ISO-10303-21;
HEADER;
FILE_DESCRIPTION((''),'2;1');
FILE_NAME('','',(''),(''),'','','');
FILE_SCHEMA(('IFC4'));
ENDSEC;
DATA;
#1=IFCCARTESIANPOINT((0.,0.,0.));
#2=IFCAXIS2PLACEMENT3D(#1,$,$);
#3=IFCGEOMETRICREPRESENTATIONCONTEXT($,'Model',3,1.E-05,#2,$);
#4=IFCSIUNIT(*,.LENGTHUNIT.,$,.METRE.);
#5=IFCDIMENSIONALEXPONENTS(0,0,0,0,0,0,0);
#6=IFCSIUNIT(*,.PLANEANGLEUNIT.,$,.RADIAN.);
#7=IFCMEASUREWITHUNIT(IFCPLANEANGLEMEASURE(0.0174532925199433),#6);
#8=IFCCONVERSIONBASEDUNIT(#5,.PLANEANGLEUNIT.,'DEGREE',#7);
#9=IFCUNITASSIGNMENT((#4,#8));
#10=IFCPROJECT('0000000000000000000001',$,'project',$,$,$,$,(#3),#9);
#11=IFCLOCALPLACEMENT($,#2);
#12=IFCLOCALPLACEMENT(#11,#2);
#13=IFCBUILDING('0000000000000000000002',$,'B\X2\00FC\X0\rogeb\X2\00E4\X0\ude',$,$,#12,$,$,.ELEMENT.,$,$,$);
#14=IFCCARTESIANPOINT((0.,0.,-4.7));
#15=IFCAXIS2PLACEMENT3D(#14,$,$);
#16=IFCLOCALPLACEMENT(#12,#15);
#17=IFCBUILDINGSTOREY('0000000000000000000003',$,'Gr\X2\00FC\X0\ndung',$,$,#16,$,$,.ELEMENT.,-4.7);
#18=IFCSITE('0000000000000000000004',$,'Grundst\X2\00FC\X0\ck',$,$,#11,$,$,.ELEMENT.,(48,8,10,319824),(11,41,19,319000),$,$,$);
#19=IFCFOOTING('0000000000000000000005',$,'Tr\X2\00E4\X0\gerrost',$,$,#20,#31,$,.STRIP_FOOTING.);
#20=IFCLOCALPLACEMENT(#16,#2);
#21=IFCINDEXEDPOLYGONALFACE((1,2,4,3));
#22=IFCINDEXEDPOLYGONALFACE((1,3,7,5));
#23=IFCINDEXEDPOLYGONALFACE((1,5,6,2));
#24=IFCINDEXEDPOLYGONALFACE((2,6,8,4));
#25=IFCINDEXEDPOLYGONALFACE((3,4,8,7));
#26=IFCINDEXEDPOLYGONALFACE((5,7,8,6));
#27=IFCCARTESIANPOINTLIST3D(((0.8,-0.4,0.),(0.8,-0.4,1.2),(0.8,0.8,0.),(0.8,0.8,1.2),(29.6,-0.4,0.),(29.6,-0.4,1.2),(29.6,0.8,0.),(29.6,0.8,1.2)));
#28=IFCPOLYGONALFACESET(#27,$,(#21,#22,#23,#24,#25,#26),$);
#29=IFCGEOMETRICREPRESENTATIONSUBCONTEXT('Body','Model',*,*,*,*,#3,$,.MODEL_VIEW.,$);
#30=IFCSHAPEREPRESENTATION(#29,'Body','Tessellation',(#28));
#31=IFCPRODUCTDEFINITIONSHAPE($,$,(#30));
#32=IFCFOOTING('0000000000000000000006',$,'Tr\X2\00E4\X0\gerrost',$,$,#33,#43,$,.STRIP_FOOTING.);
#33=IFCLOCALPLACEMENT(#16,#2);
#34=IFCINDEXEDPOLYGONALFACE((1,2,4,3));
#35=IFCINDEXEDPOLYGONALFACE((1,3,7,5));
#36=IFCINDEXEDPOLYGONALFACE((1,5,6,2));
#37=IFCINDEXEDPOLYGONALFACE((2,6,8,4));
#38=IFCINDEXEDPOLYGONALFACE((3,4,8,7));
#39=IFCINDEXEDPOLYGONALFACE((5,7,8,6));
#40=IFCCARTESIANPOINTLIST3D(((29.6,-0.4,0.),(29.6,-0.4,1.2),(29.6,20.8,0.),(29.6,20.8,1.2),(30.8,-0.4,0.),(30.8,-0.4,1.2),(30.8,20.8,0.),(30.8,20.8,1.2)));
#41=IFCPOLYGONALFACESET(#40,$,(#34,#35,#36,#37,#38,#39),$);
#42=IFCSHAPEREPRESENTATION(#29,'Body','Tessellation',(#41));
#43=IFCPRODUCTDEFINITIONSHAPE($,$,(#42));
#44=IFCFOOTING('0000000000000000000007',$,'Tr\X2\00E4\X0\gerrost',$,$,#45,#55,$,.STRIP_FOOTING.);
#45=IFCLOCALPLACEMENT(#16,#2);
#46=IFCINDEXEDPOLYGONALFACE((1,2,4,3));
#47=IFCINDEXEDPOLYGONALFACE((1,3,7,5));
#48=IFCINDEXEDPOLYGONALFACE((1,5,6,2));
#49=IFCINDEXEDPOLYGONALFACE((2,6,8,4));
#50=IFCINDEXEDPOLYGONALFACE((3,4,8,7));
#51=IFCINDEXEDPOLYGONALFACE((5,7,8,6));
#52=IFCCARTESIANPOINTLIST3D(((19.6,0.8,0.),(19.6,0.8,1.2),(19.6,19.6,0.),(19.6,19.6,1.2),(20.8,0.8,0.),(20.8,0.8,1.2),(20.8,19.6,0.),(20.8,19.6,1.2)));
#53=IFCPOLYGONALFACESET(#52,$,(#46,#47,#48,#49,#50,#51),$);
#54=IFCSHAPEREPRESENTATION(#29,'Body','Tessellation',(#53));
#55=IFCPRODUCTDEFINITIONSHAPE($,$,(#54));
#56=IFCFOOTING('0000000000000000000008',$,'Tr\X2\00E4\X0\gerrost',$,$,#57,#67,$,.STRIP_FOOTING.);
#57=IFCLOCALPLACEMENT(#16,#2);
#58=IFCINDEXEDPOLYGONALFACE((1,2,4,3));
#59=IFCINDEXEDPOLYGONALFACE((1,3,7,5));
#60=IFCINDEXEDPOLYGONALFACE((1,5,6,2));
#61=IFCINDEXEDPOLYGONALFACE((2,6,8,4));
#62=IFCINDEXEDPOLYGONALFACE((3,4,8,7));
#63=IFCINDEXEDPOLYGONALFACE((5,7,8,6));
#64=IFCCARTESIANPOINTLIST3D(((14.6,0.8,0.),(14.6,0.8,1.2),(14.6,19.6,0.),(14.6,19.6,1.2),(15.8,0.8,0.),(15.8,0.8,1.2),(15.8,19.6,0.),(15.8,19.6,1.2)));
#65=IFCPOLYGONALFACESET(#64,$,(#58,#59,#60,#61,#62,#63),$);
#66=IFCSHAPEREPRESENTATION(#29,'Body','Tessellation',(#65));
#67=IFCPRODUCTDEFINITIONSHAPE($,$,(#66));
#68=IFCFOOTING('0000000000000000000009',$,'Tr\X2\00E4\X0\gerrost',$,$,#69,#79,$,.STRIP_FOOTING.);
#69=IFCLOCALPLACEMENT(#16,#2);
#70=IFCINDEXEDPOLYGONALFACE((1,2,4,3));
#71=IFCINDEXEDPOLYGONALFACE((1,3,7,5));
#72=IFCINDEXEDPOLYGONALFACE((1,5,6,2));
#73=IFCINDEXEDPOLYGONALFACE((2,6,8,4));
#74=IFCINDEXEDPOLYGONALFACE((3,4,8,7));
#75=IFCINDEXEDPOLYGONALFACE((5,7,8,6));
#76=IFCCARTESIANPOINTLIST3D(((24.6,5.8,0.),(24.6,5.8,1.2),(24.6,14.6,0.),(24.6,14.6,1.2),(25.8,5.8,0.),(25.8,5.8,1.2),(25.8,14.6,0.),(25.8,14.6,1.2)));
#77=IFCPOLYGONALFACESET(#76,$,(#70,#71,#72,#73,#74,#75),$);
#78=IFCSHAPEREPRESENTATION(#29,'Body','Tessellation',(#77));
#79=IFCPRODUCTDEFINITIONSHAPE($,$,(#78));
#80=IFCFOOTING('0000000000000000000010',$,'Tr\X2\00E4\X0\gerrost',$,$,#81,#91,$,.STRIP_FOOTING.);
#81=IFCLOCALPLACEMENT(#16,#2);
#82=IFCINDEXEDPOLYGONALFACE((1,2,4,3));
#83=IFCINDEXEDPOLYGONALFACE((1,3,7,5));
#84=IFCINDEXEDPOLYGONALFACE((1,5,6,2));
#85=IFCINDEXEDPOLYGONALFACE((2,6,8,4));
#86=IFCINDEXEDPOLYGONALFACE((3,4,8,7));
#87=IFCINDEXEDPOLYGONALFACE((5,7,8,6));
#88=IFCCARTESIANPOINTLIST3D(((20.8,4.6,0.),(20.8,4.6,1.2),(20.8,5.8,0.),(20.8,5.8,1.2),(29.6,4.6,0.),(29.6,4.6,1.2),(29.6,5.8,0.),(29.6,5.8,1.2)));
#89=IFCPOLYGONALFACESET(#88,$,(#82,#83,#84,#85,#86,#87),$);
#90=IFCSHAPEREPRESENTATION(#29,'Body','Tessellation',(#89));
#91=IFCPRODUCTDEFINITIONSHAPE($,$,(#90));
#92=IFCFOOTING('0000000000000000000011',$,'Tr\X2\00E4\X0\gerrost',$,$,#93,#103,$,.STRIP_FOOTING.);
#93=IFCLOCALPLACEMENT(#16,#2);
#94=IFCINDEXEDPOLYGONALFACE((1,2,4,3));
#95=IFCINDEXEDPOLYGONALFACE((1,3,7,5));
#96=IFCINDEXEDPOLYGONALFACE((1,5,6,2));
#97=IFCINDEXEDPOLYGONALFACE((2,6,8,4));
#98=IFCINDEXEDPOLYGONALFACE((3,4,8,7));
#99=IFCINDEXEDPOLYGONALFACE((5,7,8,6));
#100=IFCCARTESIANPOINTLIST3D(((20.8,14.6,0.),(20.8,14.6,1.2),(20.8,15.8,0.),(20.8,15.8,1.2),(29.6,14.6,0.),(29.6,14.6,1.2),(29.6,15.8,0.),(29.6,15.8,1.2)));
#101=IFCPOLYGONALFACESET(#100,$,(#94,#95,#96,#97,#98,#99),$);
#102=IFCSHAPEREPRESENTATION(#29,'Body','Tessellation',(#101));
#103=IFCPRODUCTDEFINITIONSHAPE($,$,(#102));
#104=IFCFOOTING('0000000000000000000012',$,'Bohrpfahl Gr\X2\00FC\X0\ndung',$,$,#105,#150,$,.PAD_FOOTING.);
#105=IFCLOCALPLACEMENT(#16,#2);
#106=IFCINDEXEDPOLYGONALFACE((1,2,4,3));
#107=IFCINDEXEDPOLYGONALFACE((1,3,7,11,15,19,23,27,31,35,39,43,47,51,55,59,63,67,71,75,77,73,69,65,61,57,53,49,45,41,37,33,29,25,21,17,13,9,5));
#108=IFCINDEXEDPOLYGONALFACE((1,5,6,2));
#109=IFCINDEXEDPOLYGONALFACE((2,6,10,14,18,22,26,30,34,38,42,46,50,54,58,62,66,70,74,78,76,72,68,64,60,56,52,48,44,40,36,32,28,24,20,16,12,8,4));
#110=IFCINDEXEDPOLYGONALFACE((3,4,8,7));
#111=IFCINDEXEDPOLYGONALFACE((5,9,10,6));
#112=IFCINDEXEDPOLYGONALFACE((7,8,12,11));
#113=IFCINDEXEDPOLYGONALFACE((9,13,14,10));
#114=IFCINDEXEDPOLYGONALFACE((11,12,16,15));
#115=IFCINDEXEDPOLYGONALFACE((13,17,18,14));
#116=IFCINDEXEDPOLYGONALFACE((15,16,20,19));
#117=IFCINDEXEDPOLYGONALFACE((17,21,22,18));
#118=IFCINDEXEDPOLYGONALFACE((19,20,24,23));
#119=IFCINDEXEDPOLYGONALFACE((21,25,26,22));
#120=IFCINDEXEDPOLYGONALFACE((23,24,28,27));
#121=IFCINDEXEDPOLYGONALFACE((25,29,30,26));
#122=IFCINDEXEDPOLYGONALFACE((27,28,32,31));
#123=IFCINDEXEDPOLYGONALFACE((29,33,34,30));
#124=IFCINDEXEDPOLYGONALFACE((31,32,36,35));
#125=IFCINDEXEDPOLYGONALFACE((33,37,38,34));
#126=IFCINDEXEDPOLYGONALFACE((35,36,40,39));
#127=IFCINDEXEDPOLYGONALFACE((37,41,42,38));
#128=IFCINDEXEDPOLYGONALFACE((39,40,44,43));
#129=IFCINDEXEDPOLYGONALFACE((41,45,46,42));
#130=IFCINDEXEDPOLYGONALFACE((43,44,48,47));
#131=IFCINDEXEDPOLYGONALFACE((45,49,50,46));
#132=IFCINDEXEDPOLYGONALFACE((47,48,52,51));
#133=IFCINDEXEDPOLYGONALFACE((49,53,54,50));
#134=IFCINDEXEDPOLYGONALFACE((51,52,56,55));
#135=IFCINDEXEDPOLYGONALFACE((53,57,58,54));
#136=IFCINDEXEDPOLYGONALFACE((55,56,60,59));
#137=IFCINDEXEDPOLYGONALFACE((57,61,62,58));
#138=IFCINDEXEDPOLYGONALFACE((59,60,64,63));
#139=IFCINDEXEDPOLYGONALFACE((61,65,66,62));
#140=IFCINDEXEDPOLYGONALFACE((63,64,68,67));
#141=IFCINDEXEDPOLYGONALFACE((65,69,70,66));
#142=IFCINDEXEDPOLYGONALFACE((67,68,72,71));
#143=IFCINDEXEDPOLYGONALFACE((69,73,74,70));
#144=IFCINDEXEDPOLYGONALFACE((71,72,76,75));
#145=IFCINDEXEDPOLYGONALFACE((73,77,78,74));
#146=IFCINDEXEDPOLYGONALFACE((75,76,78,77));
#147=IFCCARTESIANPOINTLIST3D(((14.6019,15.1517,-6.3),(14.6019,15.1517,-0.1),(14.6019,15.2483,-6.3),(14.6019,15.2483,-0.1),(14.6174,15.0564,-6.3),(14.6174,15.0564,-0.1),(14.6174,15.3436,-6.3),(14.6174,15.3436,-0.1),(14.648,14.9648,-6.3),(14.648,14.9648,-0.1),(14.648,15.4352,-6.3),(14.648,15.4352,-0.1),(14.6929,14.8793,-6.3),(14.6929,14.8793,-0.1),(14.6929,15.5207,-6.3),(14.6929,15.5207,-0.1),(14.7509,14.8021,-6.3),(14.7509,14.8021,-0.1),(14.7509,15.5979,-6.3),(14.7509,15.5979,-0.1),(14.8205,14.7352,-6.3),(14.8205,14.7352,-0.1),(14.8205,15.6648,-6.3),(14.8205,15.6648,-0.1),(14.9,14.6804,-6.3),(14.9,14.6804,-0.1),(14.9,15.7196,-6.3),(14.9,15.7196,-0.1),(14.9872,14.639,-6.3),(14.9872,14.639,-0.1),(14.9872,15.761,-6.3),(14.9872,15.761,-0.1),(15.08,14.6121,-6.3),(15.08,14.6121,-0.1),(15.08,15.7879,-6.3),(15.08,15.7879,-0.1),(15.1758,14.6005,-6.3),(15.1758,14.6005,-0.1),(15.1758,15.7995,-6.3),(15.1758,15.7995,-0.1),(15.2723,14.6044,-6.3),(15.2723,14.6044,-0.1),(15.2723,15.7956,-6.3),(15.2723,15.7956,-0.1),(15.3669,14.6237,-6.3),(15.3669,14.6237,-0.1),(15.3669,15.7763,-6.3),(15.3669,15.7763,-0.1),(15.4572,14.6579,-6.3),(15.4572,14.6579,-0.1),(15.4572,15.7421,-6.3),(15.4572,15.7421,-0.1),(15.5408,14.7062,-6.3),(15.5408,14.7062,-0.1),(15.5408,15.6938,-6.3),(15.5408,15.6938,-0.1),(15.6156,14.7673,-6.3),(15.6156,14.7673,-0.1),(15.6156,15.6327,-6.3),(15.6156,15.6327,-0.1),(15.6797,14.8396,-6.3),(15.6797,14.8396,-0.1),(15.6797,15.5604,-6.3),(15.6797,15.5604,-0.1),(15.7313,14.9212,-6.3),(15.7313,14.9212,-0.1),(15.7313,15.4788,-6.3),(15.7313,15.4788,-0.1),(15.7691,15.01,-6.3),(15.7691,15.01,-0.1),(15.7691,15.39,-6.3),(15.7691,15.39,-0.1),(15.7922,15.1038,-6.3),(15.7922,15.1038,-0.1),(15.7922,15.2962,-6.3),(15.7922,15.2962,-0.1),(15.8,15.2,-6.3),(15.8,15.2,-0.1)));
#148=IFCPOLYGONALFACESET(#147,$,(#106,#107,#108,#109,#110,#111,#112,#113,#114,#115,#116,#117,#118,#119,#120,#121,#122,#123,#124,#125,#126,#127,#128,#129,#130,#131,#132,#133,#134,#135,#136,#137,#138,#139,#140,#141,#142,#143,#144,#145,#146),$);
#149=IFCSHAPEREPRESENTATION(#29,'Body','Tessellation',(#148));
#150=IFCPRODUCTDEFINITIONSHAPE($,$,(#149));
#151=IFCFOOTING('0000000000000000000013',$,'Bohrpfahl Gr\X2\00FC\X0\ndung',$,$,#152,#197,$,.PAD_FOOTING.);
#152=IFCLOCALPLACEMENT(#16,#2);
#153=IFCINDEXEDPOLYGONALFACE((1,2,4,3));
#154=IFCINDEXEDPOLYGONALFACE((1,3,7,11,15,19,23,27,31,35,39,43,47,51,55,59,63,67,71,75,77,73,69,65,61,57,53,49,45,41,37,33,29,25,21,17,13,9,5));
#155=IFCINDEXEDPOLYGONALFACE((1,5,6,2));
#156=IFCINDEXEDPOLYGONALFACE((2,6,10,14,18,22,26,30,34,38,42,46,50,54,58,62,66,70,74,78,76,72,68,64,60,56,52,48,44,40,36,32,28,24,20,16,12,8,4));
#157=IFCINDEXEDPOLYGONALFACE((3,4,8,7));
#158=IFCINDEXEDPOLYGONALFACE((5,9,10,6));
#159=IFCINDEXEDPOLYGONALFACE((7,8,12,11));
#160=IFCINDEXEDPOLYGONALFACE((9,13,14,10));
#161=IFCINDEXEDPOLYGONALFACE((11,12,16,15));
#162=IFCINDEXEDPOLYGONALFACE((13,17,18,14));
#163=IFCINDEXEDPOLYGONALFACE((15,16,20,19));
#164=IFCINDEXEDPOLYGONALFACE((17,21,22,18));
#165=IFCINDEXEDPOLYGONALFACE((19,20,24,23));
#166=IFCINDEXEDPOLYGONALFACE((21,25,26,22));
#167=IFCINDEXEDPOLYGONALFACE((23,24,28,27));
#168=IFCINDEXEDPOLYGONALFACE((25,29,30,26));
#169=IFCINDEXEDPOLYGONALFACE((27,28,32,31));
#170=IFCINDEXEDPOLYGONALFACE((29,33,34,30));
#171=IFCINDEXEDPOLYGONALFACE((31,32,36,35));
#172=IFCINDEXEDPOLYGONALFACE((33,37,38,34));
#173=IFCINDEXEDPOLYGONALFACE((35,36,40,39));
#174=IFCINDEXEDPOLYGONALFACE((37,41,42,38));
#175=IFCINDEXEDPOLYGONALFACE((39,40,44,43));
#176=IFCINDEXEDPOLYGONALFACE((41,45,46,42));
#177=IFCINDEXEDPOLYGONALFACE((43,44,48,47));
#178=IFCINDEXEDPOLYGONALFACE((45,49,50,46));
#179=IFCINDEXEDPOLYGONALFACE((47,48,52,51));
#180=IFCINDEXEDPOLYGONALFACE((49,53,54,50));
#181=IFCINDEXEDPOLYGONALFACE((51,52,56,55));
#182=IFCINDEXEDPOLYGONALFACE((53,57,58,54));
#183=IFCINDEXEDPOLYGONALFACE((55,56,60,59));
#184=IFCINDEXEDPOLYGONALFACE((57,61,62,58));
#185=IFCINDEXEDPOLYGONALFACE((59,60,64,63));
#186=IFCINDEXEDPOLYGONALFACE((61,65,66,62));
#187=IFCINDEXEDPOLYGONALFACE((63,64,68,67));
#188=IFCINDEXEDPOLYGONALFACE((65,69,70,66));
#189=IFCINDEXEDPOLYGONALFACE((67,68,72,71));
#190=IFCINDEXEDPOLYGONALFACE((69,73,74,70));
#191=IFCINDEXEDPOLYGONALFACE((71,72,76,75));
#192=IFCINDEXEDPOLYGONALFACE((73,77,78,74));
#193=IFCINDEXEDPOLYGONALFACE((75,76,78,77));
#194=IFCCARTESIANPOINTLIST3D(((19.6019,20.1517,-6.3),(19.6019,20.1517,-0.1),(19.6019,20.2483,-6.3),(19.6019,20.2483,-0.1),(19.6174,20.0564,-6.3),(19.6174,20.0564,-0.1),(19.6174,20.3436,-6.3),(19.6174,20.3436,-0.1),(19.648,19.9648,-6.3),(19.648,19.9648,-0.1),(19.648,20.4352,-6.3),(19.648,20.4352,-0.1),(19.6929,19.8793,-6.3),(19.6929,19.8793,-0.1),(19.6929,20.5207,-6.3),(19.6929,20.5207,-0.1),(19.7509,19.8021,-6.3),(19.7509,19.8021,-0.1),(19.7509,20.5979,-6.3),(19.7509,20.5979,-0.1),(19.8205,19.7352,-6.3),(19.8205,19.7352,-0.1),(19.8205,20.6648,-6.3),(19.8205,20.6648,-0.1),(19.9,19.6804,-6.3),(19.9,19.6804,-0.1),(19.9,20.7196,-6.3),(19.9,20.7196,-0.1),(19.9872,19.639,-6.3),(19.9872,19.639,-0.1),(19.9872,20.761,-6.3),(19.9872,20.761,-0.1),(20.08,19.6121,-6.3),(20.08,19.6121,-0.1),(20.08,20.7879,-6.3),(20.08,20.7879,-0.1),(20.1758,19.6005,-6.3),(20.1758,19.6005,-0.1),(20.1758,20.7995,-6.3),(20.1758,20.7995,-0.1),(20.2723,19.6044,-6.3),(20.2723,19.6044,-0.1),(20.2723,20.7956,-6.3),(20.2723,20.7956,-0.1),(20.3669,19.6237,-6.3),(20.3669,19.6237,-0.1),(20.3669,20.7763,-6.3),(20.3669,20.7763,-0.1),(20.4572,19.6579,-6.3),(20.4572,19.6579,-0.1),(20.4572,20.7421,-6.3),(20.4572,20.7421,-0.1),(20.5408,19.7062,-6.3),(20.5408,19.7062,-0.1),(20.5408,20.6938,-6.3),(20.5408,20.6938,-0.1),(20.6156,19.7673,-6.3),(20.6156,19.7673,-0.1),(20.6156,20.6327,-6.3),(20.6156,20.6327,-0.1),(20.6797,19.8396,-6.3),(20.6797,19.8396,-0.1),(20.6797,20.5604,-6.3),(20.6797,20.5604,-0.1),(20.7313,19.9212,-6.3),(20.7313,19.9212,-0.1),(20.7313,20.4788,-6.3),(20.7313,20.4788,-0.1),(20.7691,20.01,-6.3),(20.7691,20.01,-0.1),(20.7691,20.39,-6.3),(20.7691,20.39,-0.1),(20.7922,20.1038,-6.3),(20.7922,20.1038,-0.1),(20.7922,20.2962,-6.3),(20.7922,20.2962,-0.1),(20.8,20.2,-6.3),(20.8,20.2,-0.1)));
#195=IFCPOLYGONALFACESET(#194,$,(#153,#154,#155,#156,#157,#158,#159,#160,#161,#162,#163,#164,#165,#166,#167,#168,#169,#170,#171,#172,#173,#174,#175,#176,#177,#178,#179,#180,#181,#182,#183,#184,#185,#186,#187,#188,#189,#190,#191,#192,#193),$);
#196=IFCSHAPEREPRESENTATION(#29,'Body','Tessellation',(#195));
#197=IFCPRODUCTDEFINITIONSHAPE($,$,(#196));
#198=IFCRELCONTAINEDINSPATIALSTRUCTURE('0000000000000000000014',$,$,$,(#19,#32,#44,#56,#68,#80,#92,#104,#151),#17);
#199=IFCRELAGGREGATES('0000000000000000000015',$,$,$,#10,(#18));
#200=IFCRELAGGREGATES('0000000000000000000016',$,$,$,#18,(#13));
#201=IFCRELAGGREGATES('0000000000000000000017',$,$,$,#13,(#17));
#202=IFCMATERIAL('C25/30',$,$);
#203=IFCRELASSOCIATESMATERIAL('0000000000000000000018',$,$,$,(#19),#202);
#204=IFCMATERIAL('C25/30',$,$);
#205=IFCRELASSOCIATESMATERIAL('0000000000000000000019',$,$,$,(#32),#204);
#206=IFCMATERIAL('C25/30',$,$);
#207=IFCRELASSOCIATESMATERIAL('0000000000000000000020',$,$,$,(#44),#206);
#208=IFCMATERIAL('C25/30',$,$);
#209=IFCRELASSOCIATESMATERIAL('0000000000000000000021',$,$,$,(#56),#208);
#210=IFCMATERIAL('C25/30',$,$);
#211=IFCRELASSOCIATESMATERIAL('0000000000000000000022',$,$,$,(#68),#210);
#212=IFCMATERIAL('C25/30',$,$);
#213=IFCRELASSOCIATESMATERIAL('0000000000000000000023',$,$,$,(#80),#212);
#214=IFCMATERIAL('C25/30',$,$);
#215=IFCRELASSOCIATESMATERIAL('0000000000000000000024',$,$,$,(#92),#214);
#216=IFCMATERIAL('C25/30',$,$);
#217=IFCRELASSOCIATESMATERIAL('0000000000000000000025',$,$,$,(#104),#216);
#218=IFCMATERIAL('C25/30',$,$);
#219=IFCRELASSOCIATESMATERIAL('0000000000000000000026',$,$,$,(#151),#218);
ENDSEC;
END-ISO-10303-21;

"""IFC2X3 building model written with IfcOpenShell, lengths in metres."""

from ifc_helpers import new_model, entity, si_unit, converted_unit, frame, frame_2d, origin, place, context, subcontext, project, spatial, rectangle, circle, extrude, material, element, save


model = new_model("IFC2X3")

# Units and contexts
model_context = context("Model", 3, precision=1e-05, world=origin())
body_context = subcontext(model_context, "Body", "Model", "MODEL_VIEW")
ifc_project = project(units=[si_unit("LENGTHUNIT", "METRE"), converted_unit("PLANEANGLEUNIT", "DEGREE", entity("IfcPlaneAngleMeasure", 0.0174532925199433), si_unit("PLANEANGLEUNIT", "RADIAN"), dimensions=[0, 0, 0, 0, 0, 0, 0])], contexts=[model_context])

# Site, building, storey
site_placement = place(None, origin())
site = spatial("IfcSite", under=ifc_project, at=site_placement, Name="Grundstück", CompositionType="ELEMENT", RefLatitude=(48, 8, 10, 319824), RefLongitude=(11, 41, 19, 319000))
building_placement = place(site_placement, origin())
building = spatial("IfcBuilding", under=site, at=building_placement, Name="Bürogebäude", CompositionType="ELEMENT")
storey_placement = place(building_placement, frame((0.0, 0.0, -4.7)))
storey = spatial("IfcBuildingStorey", under=building, at=storey_placement, Name="Gründung", CompositionType="ELEMENT", Elevation=-4.7)

# Footings
ifc_material_1 = material(Name="C25/30")
footing_1_placement = place(storey_placement, frame((29.6, 0.8, 0.0), z_axis=(0.0, 0.0, 1.0), x_axis=(-1.0, 0.0, 0.0)))
element("IfcFooting", 1, at=footing_1_placement, inside=storey, material=ifc_material_1, Name="Trägerrost", PredefinedType="STRIP_FOOTING", context=body_context, shape_type="SweptSolid", body=[
    extrude(rectangle(XDim=1.2, YDim=1.2, at=frame_2d((0.6, 0.6), x_axis=(1.0, 0.0))), frame((0.0, 0.0, 0.0), z_axis=(1.0, 0.0, 0.0), x_axis=(0.0, 1.0, 0.0)), (0.0, 0.0, 1.0), 28.8),
])
ifc_material_2 = material(Name="C25/30")
footing_2_placement = place(storey_placement, frame((29.6, 20.8, 0.0), z_axis=(0.0, 0.0, 1.0), x_axis=(0.0, -1.0, 0.0)))
element("IfcFooting", 2, at=footing_2_placement, inside=storey, material=ifc_material_2, Name="Trägerrost", PredefinedType="STRIP_FOOTING", context=body_context, shape_type="SweptSolid", body=[
    extrude(rectangle(XDim=1.2, YDim=1.2, at=frame_2d((0.6, 0.6), x_axis=(1.0, 0.0))), frame((0.0, 0.0, 0.0), z_axis=(1.0, 0.0, 0.0), x_axis=(0.0, 1.0, 0.0)), (0.0, 0.0, 1.0), 21.2),
])
ifc_material_3 = material(Name="C25/30")
footing_3_placement = place(storey_placement, frame((20.8, 0.8, 0.0), z_axis=(0.0, 0.0, 1.0), x_axis=(0.0, 1.0, 0.0)))
element("IfcFooting", 3, at=footing_3_placement, inside=storey, material=ifc_material_3, Name="Trägerrost", PredefinedType="STRIP_FOOTING", context=body_context, shape_type="SweptSolid", body=[
    extrude(rectangle(XDim=1.2, YDim=1.2, at=frame_2d((0.6, 0.6), x_axis=(1.0, 0.0))), frame((0.0, 0.0, 0.0), z_axis=(1.0, 0.0, 0.0), x_axis=(0.0, 1.0, 0.0)), (0.0, 0.0, 1.0), 18.8),
])
ifc_material_4 = material(Name="C25/30")
footing_4_placement = place(storey_placement, frame((15.8, 0.8, 0.0), z_axis=(0.0, 0.0, 1.0), x_axis=(0.0, 1.0, 0.0)))
element("IfcFooting", 4, at=footing_4_placement, inside=storey, material=ifc_material_4, Name="Trägerrost", PredefinedType="STRIP_FOOTING", context=body_context, shape_type="SweptSolid", body=[
    extrude(rectangle(XDim=1.2, YDim=1.2, at=frame_2d((0.6, 0.6), x_axis=(1.0, 0.0))), frame((0.0, 0.0, 0.0), z_axis=(1.0, 0.0, 0.0), x_axis=(0.0, 1.0, 0.0)), (0.0, 0.0, 1.0), 18.8),
])
ifc_material_5 = material(Name="C25/30")
footing_5_placement = place(storey_placement, frame((24.6, 14.6, 0.0), z_axis=(0.0, 0.0, 1.0), x_axis=(0.0, -1.0, 0.0)))
element("IfcFooting", 5, at=footing_5_placement, inside=storey, material=ifc_material_5, Name="Trägerrost", PredefinedType="STRIP_FOOTING", context=body_context, shape_type="SweptSolid", body=[
    extrude(rectangle(XDim=1.2, YDim=1.2, at=frame_2d((0.6, 0.6), x_axis=(1.0, 0.0))), frame((0.0, 0.0, 0.0), z_axis=(1.0, 0.0, 0.0), x_axis=(0.0, 1.0, 0.0)), (0.0, 0.0, 1.0), 8.8),
])
ifc_material_6 = material(Name="C25/30")
footing_6_placement = place(storey_placement, frame((29.6, 5.8, 0.0), z_axis=(0.0, 0.0, 1.0), x_axis=(-1.0, 0.0, 0.0)))
element("IfcFooting", 6, at=footing_6_placement, inside=storey, material=ifc_material_6, Name="Trägerrost", PredefinedType="STRIP_FOOTING", context=body_context, shape_type="SweptSolid", body=[
    extrude(rectangle(XDim=1.2, YDim=1.2, at=frame_2d((0.6, 0.6), x_axis=(1.0, 0.0))), frame((0.0, 0.0, 0.0), z_axis=(1.0, 0.0, 0.0), x_axis=(0.0, 1.0, 0.0)), (0.0, 0.0, 1.0), 8.8),
])
ifc_material_7 = material(Name="C25/30")
footing_7_placement = place(storey_placement, frame((20.8, 14.6, 0.0)))
element("IfcFooting", 7, at=footing_7_placement, inside=storey, material=ifc_material_7, Name="Trägerrost", PredefinedType="STRIP_FOOTING", context=body_context, shape_type="SweptSolid", body=[
    extrude(rectangle(XDim=1.2, YDim=1.2, at=frame_2d((0.6, 0.6), x_axis=(1.0, 0.0))), frame((0.0, 0.0, 0.0), z_axis=(1.0, 0.0, 0.0), x_axis=(0.0, 1.0, 0.0)), (0.0, 0.0, 1.0), 8.8),
])
ifc_material_8 = material(Name="C25/30")
footing_8_placement = place(storey_placement, frame((14.6025, 14.6025, -6.3)))
element("IfcFooting", 8, at=footing_8_placement, inside=storey, material=ifc_material_8, Name="Bohrpfahl Gründung", PredefinedType="PAD_FOOTING", context=body_context, shape_type="SweptSolid", body=[
    extrude(circle(Radius=0.6, at=frame_2d((0.6, 0.6), x_axis=(1.0, 0.0))), frame((-0.0025, -0.0025, 0.0), z_axis=(0.0, 0.0, 1.0), x_axis=(1.0, 0.0, 0.0)), (0.0, 0.0, 1.0), 6.2),
])
ifc_material_9 = material(Name="C25/30")
footing_9_placement = place(storey_placement, frame((19.6025, 19.6025, -6.3)))
element("IfcFooting", 9, at=footing_9_placement, inside=storey, material=ifc_material_9, Name="Bohrpfahl Gründung", PredefinedType="PAD_FOOTING", context=body_context, shape_type="SweptSolid", body=[
    extrude(circle(Radius=0.6, at=frame_2d((0.6, 0.6), x_axis=(1.0, 0.0))), frame((-0.0025, -0.0025, 0.0), z_axis=(0.0, 0.0, 1.0), x_axis=(1.0, 0.0, 0.0)), (0.0, 0.0, 1.0), 6.2),
])

save(model, "model.ifc")
